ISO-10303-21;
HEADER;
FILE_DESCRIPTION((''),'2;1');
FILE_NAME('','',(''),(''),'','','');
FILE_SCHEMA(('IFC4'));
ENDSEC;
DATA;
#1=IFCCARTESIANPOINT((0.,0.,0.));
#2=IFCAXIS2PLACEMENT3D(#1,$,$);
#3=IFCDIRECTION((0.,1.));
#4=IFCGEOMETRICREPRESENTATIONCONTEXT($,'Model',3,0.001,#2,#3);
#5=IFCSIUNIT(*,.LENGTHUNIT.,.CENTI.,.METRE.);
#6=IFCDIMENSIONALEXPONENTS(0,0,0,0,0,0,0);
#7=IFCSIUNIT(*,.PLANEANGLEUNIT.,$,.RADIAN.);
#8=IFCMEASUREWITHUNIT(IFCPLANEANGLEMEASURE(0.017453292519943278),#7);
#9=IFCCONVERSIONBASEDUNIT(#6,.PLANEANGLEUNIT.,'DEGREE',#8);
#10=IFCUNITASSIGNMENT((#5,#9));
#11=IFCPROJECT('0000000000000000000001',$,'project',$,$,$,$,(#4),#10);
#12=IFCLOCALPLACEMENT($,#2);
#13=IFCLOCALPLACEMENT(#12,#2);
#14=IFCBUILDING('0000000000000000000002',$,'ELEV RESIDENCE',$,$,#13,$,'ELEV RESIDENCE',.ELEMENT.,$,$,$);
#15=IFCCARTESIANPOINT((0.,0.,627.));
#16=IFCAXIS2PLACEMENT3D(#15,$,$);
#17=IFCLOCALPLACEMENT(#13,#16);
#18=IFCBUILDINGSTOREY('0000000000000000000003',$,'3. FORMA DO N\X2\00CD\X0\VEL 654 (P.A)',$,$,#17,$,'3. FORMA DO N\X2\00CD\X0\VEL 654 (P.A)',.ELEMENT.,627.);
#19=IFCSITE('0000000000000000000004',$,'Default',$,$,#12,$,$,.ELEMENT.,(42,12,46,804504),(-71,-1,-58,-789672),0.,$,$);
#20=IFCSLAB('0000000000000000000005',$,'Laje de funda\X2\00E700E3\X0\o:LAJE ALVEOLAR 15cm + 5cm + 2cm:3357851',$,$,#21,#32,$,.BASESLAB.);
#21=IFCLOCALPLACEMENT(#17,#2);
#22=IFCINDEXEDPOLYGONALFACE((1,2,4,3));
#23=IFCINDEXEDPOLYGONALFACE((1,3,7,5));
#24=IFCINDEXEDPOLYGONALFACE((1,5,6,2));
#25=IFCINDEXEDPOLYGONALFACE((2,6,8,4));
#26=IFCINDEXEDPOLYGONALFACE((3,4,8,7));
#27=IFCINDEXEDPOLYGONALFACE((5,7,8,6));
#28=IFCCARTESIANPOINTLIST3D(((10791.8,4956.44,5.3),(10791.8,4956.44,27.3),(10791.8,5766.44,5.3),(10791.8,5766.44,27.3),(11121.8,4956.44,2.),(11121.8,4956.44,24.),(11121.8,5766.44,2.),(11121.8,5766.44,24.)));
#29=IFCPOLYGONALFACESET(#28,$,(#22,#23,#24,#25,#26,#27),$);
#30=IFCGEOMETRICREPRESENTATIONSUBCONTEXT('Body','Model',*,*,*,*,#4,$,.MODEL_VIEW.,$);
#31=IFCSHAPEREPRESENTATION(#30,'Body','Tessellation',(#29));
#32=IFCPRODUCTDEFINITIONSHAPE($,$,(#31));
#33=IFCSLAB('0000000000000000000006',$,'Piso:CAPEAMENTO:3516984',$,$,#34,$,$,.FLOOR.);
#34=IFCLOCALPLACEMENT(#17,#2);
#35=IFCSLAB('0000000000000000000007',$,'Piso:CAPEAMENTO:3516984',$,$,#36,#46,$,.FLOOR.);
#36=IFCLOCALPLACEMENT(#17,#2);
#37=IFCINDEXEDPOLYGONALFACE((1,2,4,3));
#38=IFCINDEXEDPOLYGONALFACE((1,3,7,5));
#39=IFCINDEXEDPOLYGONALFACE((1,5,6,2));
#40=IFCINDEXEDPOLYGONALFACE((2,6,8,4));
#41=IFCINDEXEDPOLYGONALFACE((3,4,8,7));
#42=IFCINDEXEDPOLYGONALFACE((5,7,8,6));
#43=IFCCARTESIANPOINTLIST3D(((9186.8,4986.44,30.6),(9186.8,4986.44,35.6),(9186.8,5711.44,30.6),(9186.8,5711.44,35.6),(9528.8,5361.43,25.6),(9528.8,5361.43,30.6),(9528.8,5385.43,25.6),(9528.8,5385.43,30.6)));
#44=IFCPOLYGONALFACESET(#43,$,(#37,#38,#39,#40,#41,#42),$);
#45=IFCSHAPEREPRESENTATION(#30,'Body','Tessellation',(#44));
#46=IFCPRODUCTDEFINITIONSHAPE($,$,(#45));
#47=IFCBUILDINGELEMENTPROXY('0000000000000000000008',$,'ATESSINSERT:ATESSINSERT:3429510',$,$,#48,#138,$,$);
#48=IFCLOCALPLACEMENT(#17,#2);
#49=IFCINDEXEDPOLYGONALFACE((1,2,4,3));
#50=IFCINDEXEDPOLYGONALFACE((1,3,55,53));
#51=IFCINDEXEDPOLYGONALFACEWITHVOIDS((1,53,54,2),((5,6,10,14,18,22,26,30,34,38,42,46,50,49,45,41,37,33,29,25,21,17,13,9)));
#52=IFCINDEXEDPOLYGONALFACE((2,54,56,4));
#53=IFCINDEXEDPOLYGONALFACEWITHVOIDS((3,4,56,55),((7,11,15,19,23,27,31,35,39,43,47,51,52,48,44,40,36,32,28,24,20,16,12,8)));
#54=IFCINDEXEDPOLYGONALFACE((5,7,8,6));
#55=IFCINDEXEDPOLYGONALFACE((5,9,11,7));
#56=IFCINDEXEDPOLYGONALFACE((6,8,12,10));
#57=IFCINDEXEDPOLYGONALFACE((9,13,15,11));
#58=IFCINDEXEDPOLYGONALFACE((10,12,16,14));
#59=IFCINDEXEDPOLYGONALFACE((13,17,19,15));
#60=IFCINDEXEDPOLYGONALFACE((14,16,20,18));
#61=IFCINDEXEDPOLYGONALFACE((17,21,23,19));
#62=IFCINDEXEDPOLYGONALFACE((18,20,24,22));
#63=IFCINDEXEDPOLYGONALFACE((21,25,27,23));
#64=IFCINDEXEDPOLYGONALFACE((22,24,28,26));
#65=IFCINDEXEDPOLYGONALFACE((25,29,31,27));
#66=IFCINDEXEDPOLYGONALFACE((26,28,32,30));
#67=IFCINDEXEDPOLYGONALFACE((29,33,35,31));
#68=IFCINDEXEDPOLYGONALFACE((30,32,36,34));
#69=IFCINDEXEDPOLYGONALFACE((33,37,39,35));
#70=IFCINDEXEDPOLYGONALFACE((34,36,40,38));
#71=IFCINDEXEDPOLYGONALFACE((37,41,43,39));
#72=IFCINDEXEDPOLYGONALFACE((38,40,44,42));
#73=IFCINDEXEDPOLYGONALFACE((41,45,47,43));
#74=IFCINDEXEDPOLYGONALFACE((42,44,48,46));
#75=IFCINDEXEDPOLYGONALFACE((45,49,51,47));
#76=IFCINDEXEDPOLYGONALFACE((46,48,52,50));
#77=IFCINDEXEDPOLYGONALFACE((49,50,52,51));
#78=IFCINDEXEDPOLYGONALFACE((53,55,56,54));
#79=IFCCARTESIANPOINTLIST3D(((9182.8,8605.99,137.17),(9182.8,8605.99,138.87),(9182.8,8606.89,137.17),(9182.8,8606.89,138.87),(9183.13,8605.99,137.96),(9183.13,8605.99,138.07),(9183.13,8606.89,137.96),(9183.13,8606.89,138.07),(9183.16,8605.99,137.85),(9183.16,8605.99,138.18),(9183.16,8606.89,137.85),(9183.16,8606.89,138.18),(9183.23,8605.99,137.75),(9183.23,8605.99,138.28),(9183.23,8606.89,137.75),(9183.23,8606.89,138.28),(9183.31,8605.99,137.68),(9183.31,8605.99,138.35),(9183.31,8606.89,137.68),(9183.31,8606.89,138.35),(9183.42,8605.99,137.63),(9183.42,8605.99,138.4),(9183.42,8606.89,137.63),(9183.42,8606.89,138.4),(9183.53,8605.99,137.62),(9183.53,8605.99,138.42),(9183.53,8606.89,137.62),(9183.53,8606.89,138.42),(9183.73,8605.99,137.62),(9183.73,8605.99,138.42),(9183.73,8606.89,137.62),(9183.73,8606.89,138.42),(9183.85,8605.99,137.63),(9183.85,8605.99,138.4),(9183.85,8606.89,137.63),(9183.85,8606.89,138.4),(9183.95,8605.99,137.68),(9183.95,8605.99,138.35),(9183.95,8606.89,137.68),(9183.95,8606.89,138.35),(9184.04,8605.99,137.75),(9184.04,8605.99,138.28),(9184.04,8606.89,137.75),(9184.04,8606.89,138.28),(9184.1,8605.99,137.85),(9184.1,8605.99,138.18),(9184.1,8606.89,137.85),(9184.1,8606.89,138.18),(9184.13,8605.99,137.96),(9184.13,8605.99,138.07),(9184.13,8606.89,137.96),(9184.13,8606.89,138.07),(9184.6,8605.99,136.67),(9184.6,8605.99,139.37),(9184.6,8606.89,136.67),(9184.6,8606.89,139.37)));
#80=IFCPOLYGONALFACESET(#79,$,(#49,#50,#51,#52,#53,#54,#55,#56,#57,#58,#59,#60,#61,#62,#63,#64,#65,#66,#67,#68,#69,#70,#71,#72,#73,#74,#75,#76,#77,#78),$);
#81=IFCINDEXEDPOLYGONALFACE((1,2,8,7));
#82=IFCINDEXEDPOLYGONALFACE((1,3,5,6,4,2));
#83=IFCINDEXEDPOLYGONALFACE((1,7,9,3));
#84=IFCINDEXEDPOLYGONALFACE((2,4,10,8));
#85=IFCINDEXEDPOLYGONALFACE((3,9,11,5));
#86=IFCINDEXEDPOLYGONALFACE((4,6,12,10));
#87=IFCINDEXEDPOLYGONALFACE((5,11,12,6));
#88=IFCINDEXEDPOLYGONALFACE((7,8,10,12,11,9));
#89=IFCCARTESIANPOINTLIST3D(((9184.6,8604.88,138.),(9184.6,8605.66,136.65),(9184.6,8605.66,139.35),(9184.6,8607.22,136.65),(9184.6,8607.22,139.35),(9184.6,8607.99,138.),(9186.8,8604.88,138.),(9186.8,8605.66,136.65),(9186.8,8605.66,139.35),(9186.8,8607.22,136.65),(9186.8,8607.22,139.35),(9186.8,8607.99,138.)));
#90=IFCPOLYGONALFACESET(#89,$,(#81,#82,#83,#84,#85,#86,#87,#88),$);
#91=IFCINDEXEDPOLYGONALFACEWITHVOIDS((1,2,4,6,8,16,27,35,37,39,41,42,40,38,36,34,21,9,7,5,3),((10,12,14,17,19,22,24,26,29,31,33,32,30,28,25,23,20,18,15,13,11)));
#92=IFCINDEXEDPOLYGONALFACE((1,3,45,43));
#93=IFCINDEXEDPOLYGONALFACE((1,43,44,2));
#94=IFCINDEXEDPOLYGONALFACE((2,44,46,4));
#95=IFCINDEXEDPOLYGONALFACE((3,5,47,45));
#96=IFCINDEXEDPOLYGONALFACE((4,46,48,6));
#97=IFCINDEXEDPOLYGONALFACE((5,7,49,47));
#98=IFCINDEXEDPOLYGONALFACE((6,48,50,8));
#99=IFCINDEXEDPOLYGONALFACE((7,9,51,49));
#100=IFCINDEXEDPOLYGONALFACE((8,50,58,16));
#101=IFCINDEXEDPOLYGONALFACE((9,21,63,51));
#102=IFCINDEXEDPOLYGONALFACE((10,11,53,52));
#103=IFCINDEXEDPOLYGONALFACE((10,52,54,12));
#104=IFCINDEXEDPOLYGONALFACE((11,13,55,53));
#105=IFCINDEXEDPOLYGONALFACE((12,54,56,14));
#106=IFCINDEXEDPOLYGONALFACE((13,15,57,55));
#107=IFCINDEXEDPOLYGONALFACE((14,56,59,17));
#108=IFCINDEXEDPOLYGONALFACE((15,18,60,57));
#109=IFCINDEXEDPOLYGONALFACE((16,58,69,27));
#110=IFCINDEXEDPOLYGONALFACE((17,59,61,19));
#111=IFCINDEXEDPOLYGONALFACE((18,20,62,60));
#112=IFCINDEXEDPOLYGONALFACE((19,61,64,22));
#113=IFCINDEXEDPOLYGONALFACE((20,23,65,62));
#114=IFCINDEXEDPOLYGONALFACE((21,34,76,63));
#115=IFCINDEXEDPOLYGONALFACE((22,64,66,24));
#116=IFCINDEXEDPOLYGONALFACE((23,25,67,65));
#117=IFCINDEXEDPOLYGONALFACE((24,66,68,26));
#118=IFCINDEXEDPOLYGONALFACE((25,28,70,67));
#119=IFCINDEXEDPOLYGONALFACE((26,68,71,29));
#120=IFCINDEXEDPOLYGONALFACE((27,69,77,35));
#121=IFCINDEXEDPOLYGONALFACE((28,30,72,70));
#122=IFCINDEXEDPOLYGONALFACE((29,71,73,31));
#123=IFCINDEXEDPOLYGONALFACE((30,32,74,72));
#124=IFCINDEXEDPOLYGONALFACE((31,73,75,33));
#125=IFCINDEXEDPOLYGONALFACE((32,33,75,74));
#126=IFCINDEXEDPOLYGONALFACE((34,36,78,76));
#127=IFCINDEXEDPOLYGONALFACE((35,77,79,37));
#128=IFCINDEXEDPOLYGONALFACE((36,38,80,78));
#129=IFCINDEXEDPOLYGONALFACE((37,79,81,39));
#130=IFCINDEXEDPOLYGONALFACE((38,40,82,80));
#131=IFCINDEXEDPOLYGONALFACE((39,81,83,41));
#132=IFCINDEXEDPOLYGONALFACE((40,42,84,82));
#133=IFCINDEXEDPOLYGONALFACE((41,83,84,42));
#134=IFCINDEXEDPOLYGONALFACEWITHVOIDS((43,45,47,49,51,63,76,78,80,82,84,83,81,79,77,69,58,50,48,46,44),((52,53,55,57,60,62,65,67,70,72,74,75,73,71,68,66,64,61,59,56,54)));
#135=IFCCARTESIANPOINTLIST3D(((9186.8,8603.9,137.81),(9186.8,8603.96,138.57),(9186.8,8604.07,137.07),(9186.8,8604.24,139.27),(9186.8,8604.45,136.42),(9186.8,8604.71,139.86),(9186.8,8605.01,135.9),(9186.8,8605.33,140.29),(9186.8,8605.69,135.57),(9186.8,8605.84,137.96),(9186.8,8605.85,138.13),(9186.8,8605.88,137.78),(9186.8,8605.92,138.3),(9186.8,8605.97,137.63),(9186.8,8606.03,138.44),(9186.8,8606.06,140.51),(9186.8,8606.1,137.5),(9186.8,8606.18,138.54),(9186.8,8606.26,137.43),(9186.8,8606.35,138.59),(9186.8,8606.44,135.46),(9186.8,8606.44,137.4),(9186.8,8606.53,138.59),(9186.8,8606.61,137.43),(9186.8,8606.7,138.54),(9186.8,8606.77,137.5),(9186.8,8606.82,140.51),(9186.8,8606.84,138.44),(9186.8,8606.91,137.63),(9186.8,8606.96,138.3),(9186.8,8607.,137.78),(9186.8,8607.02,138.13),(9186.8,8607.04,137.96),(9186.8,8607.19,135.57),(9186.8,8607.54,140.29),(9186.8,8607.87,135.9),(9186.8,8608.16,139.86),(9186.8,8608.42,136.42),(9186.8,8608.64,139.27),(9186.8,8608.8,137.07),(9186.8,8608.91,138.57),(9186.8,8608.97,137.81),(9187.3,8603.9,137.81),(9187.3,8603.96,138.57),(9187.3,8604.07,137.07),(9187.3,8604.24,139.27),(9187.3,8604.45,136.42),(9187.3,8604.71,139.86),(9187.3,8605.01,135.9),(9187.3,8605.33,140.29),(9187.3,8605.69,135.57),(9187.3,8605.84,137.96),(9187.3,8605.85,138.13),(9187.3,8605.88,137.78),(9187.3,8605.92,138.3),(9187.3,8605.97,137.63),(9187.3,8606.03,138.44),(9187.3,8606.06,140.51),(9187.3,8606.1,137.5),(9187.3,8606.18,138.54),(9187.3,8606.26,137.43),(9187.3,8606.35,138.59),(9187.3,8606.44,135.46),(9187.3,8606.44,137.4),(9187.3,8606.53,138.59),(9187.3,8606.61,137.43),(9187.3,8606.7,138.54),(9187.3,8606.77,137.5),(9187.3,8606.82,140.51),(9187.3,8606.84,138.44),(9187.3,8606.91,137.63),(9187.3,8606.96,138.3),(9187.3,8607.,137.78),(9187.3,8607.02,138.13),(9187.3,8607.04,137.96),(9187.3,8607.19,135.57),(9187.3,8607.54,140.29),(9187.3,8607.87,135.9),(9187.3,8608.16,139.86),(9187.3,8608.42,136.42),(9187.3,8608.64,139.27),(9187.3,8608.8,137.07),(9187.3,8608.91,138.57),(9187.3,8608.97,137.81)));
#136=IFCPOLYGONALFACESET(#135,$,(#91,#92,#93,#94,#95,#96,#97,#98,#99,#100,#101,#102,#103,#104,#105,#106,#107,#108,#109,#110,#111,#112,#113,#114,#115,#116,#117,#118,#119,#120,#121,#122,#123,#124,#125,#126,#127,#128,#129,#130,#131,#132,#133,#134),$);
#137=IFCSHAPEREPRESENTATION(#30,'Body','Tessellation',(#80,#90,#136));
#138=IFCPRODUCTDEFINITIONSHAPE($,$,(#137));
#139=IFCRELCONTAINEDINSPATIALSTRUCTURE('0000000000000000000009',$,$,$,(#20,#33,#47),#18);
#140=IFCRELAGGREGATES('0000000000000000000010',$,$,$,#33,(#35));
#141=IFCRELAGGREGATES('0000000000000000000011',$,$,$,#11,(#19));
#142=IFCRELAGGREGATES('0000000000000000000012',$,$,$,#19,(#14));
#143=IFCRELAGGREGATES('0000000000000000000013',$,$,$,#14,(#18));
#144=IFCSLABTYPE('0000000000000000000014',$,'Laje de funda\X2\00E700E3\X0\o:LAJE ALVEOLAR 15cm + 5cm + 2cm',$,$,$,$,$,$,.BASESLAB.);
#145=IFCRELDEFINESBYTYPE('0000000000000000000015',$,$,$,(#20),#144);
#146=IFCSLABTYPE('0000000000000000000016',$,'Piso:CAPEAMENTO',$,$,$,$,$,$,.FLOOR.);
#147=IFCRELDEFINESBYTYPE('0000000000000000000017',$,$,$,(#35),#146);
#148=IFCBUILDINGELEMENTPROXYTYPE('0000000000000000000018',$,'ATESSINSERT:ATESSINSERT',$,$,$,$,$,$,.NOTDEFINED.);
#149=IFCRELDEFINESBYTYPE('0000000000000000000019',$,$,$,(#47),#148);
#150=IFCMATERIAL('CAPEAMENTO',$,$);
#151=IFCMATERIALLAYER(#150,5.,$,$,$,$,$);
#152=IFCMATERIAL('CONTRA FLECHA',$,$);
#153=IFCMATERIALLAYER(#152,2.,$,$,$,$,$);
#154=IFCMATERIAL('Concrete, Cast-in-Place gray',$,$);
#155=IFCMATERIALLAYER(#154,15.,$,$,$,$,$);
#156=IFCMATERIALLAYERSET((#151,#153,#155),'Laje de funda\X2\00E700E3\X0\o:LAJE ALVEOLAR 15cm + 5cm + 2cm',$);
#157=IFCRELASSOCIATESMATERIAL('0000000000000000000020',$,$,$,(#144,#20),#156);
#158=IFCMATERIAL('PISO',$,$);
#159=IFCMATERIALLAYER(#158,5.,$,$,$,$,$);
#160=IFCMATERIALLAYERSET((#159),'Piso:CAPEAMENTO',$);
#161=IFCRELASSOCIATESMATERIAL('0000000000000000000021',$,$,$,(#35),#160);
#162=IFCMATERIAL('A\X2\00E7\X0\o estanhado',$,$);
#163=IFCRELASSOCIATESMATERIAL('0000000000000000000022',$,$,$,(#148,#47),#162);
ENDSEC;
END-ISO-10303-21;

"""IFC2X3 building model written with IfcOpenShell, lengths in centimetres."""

from ifc_helpers import new_model, entity, si_unit, converted_unit, direction, frame, frame_2d, origin, place, context, subcontext, project, spatial, polyline, circle_curve, parameter, trimmed, segment, composite_curve, rectangle, hollow_circle, outline, extrude, clip, halfspace, source, transform, mapped, material, layer, layer_set, layer_usage, type_object, type_shapes, element, aggregate, save


model = new_model("IFC2X3")

# Units and contexts
model_context = context("Model", 3, precision=0.001, world=origin(), true_north=direction((0.0, 1.0)))
body_context = subcontext(model_context, "Body", "Model", "MODEL_VIEW")
ifc_project = project(units=[si_unit("LENGTHUNIT", "METRE", prefix="CENTI"), converted_unit("PLANEANGLEUNIT", "DEGREE", entity("IfcPlaneAngleMeasure", 0.017453292519943278), si_unit("PLANEANGLEUNIT", "RADIAN"), dimensions=[0, 0, 0, 0, 0, 0, 0])], contexts=[model_context])

# Site, building, storey
site_placement = place(None, origin())
site = spatial("IfcSite", under=ifc_project, at=site_placement, Name="Default", CompositionType="ELEMENT", RefLatitude=(42, 12, 46, 804504), RefLongitude=(-71, -1, -58, -789672), RefElevation=0.0)
building_placement = place(site_placement, origin())
building = spatial("IfcBuilding", under=site, at=building_placement, Name="ELEV RESIDENCE", LongName="ELEV RESIDENCE", CompositionType="ELEMENT")
storey_placement = place(building_placement, frame((0.0, 0.0, 627.0)))
storey = spatial("IfcBuildingStorey", under=building, at=storey_placement, Name="3. FORMA DO NÍVEL 654 (P.A)", LongName="3. FORMA DO NÍVEL 654 (P.A)", CompositionType="ELEMENT", Elevation=627.0)

# Shared definitions
ifc_material_1 = material(Name="CAPEAMENTO")
ifc_material_2 = material(Name="CONTRA FLECHA")
ifc_material_3 = material(Name="Concrete, Cast-in-Place gray")

# Slab
ifc_layer_1 = layer(ifc_material_1, 5.0)
ifc_layer_2 = layer(ifc_material_2, 2.0)
ifc_layer_3 = layer(ifc_material_3, 15.0)
ifc_layer_set_1 = layer_set([ifc_layer_1, ifc_layer_2, ifc_layer_3], Name="Laje de fundação:LAJE ALVEOLAR 15cm + 5cm + 2cm")
ifc_layer_usage_1 = layer_usage(ifc_layer_set_1, "AXIS3", "POSITIVE", 0.0)
slab_type_1 = type_object("IfcSlabType", Name="Laje de fundação:LAJE ALVEOLAR 15cm + 5cm + 2cm", PredefinedType="BASESLAB", material=ifc_layer_set_1)
slab_1_placement = place(storey_placement, origin())
element("IfcSlab", 1, at=slab_1_placement, inside=storey, type_object=slab_type_1, material=ifc_layer_usage_1, Name="Laje de fundação:LAJE ALVEOLAR 15cm + 5cm + 2cm:3357851", PredefinedType="BASESLAB", context=body_context, shape_type="Clipping", body=[
    clip(clip(extrude(rectangle(XDim=330.02, YDim=810.0, at=frame_2d((0.0, 0.0), x_axis=(0.0, 1.0))), frame((10956.8, 5361.44, 25.65), z_axis=(-0.01, 0.0, -0.99995), x_axis=(0.0, 1.0, 0.0)), (0.0, 0.01, 0.99995), 22.0), halfspace(frame((11121.8, 5361.44, 2.0), z_axis=(-0.01, 0.0, -0.99995), x_axis=(-0.99995, 0.0, 0.01)), False)), halfspace(frame((11121.8, 5361.44, 24.0), z_axis=(0.01, 0.0, 0.99995), x_axis=(0.99995, 0.0, -0.01)), False)),
])

# Slabs
slab_2_placement = place(storey_placement, frame((9186.8, 4986.44, 25.6)))
slab_2 = element("IfcSlab", 2, at=slab_2_placement, inside=storey, Name="Piso:CAPEAMENTO:3516984", PredefinedType="FLOOR")
ifc_material_4 = material(Name="PISO")
ifc_layer_4 = layer(ifc_material_4, 5.0)
ifc_layer_set_2 = layer_set([ifc_layer_4], Name="Piso:CAPEAMENTO")
slab_type_2 = type_object("IfcSlabType", Name="Piso:CAPEAMENTO", PredefinedType="FLOOR")
slab_3_placement = place(slab_2_placement, origin())
slab_3 = element("IfcSlab", 3, at=slab_3_placement, type_object=slab_type_2, material=ifc_layer_set_2, Name="Piso:CAPEAMENTO:3516984", PredefinedType="FLOOR", context=body_context, shape_type="SweptSolid", body=[
    extrude(outline(polyline([(0.0, -362.5), (342.03, 12.5), (342.03, 36.5), (0.0, 362.5), (0.0, -362.5)])), frame((0.0, 362.5, 10.0), z_axis=(0.014618, 0.0, 0.999893), x_axis=(0.999893, 0.0, -0.014618)), (0.014618, 0.0, -0.999893), 5.0),
])
aggregate(slab_2, [slab_3])

# Building element proxy
ifc_material_5 = material(Name="Aço estanhado")
building_element_proxy_type_1 = type_object("IfcBuildingElementProxyType", Name="ATESSINSERT:ATESSINSERT", PredefinedType="NOTDEFINED", material=ifc_material_5)
shared_shape_1 = source(origin(), body_context, "Body", "SweptSolid", [
    extrude(outline(polyline([(-1.35, -0.9), (1.35, -0.9), (0.85, 0.9), (-0.85, 0.9), (-1.35, -0.9)]), holes=[composite_curve([segment(trimmed(circle_curve(frame_2d((0.0, 0.17), x_axis=(1.0, 0.0)), 0.4), [parameter(0.0)], [parameter(180.0)], True, "PARAMETER"), False, "CONTINUOUS"), segment(polyline([(0.4, 0.17), (0.4, -0.03)]), True, "CONTINUOUS"), segment(trimmed(circle_curve(frame_2d((0.0, -0.03), x_axis=(1.0, 0.0)), 0.4), [parameter(180.0)], [parameter(0.0)], True, "PARAMETER"), False, "CONTINUOUS"), segment(polyline([(-0.4, -0.03), (-0.4, 0.17)]), True, "CONTINUOUS")], self_intersect=False)]), frame((-1.4, -0.45, 30.02), z_axis=(0.0, 1.0, 0.0), x_axis=(0.0, 0.0, 1.0)), (0.0, 0.0, 1.0), 0.9),
    extrude(outline(polyline([(-0.78, -1.35), (0.78, -1.35), (1.56, 0.0), (0.78, 1.35), (-0.78, 1.35), (-1.56, 0.0), (-0.78, -1.35)])), frame((-4.5, 0.0, 30.0), z_axis=(1.0, 0.0, 0.0), x_axis=(0.0, 0.5, 0.866025)), (0.0, 0.0, 1.0), 2.2),
    extrude(hollow_circle(Radius=2.54, WallThickness=1.94, at=frame_2d((0.0, 0.0), x_axis=(1.0, 0.0))), frame((-5.0, 0.0, 30.0), z_axis=(1.0, 0.0, 0.0), x_axis=(0.0, 0.0, -1.0)), (0.0, 0.0, 1.0), 0.5),
])
type_shapes(building_element_proxy_type_1, [shared_shape_1])
for number, where, z_axis, x_axis, name in (
    (4, (9182.3, 8606.44, 108.0), (0.0, 0.0, 1.0), (-1.0, 0.0, 0.0), "ATESSINSERT:ATESSINSERT:3429510"),
):
    element("IfcBuildingElementProxy", number, at=place(storey_placement, frame(where, z_axis=z_axis, x_axis=x_axis)), inside=storey, type_object=building_element_proxy_type_1, material=ifc_material_5, Name=name, context=body_context, shape_type="MappedRepresentation", body=[
        mapped(shared_shape_1, transform((0.0, 0.0, 0.0), scale=1.0)),
    ])

save(model, "model.ifc")
